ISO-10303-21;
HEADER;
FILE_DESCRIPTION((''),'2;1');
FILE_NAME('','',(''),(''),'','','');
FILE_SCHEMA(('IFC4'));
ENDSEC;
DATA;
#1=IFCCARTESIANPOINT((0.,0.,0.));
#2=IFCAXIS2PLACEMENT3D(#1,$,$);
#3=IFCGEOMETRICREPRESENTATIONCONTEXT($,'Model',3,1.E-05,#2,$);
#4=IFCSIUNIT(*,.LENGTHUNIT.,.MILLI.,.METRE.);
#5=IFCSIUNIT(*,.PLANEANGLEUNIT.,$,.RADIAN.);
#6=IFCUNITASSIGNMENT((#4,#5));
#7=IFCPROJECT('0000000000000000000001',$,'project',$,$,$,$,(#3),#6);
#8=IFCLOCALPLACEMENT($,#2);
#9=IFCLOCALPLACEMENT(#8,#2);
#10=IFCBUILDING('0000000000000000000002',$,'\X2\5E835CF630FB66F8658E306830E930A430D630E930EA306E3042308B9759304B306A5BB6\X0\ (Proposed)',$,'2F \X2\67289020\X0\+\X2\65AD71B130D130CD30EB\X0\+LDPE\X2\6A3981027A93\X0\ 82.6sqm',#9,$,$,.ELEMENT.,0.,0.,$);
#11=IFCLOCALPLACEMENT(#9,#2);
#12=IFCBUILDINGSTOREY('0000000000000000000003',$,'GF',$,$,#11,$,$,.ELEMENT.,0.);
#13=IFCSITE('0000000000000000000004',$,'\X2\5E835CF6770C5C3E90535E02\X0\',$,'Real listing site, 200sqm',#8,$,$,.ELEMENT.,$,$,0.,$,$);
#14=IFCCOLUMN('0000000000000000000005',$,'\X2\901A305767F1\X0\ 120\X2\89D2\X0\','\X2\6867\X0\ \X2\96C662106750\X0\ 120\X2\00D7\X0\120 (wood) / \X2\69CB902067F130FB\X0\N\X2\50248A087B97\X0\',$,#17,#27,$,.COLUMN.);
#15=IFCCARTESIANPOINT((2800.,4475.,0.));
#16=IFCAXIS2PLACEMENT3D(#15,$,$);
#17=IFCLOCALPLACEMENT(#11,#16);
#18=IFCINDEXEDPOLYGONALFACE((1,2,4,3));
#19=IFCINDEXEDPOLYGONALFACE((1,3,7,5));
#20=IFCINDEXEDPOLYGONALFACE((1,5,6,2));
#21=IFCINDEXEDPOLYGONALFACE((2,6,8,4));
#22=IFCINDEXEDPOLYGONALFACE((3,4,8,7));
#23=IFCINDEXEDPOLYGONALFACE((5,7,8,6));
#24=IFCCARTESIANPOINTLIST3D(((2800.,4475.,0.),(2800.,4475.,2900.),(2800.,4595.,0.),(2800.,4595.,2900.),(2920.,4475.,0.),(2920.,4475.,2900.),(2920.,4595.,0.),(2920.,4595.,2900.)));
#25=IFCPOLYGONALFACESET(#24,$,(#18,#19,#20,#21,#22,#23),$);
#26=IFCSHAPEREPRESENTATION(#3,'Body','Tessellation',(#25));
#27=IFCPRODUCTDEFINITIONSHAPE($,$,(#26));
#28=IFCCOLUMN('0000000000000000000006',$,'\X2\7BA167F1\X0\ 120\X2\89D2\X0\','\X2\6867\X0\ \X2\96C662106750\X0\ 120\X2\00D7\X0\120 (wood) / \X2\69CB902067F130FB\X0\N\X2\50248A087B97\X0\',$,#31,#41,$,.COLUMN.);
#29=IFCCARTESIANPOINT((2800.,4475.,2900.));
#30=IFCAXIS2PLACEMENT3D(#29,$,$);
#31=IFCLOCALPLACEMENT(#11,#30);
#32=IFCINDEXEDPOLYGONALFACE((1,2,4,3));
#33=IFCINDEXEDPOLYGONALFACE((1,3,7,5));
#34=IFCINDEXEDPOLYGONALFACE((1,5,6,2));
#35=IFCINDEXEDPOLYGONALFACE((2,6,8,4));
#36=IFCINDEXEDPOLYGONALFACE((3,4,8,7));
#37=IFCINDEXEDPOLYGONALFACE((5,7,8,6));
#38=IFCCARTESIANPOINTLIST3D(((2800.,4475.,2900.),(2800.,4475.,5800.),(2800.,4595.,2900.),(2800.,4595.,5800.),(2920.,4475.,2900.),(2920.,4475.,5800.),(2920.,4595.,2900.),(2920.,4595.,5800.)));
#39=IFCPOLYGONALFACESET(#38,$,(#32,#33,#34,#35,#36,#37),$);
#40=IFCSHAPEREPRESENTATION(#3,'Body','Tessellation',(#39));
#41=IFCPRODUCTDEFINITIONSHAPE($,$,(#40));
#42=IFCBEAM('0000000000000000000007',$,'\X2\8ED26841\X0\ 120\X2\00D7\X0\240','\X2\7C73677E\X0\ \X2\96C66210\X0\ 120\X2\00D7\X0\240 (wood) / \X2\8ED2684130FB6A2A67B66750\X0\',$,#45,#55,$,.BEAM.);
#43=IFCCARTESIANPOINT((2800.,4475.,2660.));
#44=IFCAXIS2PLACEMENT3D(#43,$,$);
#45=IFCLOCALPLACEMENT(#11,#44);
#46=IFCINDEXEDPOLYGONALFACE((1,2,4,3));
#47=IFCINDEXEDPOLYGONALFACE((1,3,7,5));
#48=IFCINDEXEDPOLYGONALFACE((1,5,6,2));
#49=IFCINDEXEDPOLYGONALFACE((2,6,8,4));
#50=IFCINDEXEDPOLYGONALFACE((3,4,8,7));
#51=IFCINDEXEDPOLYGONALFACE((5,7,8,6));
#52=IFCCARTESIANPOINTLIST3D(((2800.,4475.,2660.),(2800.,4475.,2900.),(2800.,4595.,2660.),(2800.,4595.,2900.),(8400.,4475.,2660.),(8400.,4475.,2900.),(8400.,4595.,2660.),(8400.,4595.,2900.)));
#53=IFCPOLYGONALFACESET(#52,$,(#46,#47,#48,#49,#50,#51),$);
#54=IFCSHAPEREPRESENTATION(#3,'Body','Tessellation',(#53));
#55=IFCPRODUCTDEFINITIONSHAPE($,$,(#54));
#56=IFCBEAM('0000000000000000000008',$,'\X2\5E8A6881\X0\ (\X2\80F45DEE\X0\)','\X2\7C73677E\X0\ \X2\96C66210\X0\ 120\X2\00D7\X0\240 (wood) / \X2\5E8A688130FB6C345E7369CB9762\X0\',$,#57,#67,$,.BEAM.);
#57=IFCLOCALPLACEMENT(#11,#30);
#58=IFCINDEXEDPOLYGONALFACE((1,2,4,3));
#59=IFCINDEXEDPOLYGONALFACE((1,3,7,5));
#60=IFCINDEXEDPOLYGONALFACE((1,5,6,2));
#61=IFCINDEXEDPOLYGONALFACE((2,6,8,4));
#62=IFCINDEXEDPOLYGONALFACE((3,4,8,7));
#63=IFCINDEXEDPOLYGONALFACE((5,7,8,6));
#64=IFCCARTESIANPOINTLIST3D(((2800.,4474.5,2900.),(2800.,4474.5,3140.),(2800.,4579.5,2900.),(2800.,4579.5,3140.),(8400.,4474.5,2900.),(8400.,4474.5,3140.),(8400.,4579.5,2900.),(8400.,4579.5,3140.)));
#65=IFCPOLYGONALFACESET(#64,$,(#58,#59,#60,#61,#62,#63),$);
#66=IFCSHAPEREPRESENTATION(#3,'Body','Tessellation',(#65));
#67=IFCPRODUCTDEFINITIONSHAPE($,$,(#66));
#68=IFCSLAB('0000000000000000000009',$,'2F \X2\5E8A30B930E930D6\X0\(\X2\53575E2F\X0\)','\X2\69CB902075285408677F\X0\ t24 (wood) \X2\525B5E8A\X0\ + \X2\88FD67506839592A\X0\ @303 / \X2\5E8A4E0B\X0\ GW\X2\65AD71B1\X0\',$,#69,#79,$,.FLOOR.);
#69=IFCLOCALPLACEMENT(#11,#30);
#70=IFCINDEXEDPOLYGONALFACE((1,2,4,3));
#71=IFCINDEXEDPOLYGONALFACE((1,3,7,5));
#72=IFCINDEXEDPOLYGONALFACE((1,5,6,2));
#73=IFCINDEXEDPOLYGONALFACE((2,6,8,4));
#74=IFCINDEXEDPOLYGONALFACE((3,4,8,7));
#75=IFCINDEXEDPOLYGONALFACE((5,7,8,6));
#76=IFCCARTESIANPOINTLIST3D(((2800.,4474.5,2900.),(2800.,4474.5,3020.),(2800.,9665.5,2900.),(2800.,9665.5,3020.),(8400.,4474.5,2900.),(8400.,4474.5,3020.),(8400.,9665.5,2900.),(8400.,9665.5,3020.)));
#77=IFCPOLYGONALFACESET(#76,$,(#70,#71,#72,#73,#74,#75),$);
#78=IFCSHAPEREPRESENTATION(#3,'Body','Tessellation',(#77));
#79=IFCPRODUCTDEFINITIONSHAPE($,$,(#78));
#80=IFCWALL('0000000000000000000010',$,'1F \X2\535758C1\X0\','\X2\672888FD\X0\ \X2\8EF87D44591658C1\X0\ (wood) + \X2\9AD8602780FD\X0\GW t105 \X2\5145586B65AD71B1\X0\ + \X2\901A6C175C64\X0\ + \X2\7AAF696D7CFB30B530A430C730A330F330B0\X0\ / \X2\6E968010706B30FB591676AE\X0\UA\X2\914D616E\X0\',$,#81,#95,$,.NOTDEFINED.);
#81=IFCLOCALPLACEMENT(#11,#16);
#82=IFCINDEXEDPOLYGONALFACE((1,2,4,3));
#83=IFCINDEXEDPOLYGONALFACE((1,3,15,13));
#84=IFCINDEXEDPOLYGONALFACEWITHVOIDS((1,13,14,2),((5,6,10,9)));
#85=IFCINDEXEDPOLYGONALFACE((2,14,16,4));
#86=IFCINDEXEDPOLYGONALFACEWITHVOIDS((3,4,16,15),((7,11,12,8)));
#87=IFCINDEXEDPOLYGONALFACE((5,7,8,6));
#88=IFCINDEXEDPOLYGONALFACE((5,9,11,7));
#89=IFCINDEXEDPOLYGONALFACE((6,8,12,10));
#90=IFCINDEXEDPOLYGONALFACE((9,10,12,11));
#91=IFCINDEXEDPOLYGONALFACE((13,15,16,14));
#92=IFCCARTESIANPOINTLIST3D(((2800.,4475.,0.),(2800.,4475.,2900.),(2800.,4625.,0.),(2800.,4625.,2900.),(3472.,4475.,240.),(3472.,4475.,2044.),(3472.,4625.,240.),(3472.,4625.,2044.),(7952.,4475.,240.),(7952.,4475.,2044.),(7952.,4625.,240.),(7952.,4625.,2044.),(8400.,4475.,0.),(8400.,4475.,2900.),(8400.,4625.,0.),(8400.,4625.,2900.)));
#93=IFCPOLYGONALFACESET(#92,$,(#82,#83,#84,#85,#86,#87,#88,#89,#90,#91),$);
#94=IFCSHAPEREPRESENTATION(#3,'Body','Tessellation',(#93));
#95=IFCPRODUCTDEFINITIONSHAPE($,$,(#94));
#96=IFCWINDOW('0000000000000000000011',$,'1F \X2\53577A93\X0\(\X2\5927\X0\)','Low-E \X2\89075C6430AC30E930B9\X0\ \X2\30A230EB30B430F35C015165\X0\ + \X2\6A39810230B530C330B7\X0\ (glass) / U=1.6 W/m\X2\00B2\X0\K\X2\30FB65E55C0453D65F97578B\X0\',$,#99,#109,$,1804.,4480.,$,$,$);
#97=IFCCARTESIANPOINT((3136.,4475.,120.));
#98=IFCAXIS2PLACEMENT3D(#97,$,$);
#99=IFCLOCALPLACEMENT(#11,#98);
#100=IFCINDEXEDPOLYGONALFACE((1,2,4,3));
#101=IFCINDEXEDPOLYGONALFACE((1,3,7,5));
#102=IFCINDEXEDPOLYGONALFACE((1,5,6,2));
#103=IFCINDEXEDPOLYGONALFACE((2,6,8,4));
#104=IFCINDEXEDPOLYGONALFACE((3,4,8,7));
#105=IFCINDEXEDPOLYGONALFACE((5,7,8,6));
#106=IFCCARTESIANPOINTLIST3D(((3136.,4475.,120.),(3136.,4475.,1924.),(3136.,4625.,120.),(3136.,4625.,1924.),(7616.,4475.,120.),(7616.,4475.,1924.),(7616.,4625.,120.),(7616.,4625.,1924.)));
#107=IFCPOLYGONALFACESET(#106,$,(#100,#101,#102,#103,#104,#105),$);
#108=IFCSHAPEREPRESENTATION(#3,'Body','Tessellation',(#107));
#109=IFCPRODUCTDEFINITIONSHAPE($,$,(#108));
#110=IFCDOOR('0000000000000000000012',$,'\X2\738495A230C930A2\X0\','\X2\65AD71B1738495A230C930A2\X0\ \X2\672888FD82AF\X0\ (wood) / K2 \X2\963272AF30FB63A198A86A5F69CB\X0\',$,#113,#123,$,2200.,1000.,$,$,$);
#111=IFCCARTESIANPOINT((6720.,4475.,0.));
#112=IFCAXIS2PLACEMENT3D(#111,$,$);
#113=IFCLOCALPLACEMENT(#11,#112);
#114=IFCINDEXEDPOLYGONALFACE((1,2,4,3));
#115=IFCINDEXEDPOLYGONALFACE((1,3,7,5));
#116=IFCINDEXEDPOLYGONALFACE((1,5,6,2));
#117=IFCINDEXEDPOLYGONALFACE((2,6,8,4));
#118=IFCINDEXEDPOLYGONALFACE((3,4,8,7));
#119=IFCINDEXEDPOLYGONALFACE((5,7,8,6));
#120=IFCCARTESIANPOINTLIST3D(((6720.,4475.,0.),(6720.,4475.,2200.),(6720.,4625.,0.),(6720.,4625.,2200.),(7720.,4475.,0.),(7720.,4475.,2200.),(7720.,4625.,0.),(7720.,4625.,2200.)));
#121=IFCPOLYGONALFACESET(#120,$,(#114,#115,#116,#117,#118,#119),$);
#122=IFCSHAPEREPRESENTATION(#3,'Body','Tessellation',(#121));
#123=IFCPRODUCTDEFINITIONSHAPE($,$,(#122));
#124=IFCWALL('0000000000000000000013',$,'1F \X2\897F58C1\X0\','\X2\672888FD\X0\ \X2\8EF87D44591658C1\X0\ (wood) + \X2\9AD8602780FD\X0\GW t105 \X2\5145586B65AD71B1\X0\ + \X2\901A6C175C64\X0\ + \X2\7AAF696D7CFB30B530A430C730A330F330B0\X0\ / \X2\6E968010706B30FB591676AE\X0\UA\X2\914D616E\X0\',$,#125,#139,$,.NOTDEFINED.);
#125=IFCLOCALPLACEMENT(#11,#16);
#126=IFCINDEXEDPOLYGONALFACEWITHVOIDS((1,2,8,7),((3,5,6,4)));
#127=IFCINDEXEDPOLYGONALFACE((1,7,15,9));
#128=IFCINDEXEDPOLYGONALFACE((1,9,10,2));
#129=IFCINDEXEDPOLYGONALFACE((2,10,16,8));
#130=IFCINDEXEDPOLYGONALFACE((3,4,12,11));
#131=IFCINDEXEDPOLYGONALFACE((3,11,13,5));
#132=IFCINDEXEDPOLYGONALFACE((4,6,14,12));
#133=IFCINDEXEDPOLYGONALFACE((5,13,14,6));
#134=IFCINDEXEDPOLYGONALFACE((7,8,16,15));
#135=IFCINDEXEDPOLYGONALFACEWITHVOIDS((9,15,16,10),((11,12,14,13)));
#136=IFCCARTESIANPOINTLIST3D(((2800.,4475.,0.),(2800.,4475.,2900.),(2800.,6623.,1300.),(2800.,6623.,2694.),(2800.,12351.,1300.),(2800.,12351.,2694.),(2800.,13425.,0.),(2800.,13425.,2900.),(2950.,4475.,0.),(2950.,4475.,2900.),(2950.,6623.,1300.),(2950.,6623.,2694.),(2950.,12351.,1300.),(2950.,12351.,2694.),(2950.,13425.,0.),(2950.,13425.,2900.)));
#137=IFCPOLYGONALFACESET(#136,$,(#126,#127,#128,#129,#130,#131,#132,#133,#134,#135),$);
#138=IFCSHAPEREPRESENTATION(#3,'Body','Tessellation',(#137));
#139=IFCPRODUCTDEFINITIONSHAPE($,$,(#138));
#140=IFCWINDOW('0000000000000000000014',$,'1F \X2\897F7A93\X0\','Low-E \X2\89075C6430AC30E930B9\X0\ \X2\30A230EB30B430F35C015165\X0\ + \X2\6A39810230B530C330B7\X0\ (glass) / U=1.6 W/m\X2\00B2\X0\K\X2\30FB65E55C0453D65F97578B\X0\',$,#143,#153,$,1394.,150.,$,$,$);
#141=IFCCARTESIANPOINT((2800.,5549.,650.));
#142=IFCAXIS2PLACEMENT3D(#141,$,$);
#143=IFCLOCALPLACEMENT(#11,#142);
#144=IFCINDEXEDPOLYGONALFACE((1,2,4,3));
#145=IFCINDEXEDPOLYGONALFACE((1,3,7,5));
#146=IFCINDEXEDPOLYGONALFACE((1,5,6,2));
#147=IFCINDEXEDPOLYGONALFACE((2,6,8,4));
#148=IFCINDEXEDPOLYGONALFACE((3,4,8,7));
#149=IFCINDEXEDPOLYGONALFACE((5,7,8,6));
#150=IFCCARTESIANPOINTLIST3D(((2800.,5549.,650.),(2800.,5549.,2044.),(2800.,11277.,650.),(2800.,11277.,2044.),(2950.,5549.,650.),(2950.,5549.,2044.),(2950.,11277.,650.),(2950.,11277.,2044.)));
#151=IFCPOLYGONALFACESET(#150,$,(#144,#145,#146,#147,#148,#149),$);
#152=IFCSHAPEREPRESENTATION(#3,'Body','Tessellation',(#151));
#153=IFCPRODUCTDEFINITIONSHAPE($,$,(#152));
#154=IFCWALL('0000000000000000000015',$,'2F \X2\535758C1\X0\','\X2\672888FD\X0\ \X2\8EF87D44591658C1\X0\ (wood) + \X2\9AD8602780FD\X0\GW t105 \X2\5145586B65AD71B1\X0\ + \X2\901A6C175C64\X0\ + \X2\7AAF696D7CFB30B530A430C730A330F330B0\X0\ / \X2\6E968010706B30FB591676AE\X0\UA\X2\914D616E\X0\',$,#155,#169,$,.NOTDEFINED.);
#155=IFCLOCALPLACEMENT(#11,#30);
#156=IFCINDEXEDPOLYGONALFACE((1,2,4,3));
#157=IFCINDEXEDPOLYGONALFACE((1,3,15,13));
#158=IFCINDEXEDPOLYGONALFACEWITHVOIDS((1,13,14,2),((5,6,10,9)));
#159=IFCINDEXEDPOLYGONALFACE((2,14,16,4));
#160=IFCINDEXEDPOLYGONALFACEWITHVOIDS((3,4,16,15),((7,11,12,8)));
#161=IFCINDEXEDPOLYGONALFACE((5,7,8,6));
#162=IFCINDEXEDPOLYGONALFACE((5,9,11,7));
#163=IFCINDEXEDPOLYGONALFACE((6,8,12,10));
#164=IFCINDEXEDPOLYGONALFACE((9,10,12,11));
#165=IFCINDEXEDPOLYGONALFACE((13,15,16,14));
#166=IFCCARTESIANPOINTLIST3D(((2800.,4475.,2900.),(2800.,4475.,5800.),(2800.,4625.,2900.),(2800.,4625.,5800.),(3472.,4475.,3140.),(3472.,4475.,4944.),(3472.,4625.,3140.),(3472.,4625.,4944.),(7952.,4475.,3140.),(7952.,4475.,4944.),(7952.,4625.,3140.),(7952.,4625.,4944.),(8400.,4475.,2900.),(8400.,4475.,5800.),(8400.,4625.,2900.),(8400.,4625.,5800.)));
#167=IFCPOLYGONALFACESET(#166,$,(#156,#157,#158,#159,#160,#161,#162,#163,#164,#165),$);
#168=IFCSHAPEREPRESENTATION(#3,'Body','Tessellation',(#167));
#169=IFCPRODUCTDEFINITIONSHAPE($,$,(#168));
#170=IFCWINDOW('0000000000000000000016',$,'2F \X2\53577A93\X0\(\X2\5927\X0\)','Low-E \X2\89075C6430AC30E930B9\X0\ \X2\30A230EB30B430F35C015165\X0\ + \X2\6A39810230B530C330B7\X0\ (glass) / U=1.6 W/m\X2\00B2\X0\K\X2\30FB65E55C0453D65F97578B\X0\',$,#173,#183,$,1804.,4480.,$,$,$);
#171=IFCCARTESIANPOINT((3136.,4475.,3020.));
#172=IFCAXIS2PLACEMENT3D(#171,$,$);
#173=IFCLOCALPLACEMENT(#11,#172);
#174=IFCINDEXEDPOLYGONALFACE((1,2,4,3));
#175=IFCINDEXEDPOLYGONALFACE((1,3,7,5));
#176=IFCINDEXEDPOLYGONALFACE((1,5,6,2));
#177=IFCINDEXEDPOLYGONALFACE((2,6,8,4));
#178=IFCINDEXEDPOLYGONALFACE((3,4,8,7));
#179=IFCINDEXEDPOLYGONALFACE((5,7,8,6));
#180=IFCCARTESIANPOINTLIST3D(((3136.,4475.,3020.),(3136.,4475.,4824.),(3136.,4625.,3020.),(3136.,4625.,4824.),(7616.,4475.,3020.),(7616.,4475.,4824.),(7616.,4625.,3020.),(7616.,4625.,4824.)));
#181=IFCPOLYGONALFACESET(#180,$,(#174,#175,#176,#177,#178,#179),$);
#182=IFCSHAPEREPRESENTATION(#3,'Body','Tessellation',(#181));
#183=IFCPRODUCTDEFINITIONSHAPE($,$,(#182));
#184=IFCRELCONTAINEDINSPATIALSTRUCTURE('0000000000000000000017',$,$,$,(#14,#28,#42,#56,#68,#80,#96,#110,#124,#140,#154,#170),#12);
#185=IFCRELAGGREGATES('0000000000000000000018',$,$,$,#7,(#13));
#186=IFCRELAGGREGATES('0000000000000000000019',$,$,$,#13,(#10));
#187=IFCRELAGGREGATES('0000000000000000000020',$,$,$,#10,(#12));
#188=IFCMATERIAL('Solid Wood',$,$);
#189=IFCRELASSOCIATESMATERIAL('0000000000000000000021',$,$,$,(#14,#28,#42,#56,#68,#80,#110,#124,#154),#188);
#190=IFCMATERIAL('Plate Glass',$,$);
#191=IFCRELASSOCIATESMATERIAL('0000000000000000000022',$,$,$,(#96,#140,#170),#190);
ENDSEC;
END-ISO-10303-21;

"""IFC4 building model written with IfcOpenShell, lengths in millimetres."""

from ifc_helpers import new_model, si_unit, frame, frame_2d, origin, place, context, project, spatial, rectangle, extrude, material, element, fill, save


model = new_model("IFC4")

# Units and contexts
model_context = context("Model", 3, precision=1e-05, world=origin())
ifc_project = project(units=[si_unit("LENGTHUNIT", "METRE", prefix="MILLI"), si_unit("PLANEANGLEUNIT", "RADIAN")], contexts=[model_context])

# Site, building, storey
site_placement = place(None, origin())
site = spatial("IfcSite", under=ifc_project, at=site_placement, Name="広島県尾道市", ObjectType="Real listing site, 200sqm", CompositionType="ELEMENT", RefElevation=0.0)
building_placement = place(site_placement, origin())
building = spatial("IfcBuilding", under=site, at=building_placement, Name="広島・書斎とライブラリのある静かな家 (Proposed)", ObjectType="2F 木造+断熱パネル+LDPE樹脂窓 82.6sqm", CompositionType="ELEMENT", ElevationOfRefHeight=0.0, ElevationOfTerrain=0.0)
storey_placement = place(building_placement, origin())
storey = spatial("IfcBuildingStorey", under=building, at=storey_placement, Name="GF", CompositionType="ELEMENT", Elevation=0.0)

# Columns
ifc_material_1 = material(Name="Solid Wood")
column_1_placement = place(storey_placement, frame((2800.0, 4475.0, 0.0)))
element("IfcColumn", 1, at=column_1_placement, inside=storey, material=ifc_material_1, Name="通し柱 120角", Description="桧 集成材 120×120 (wood) / 構造柱・N値計算", PredefinedType="COLUMN", context=model_context, shape_type="SweptSolid", body=[
    extrude(rectangle(XDim=120.0, YDim=120.0, at=frame_2d((60.0, 60.0))), frame((2800.0, 4475.0, 0.0)), (0.0, 0.0, 1.0), 2900.0),
])
column_2_placement = place(storey_placement, frame((2800.0, 4475.0, 2900.0)))
element("IfcColumn", 2, at=column_2_placement, inside=storey, material=ifc_material_1, Name="管柱 120角", Description="桧 集成材 120×120 (wood) / 構造柱・N値計算", PredefinedType="COLUMN", context=model_context, shape_type="SweptSolid", body=[
    extrude(rectangle(XDim=120.0, YDim=120.0, at=frame_2d((60.0, 60.0))), frame((2800.0, 4475.0, 2900.0)), (0.0, 0.0, 1.0), 2900.0),
])

# Beams
beam_1_placement = place(storey_placement, frame((2800.0, 4475.0, 2660.0)))
element("IfcBeam", 3, at=beam_1_placement, inside=storey, material=ifc_material_1, Name="軒桁 120×240", Description="米松 集成 120×240 (wood) / 軒桁・横架材", PredefinedType="BEAM", context=model_context, shape_type="SweptSolid", body=[
    extrude(rectangle(XDim=5600.0, YDim=120.0, at=frame_2d((2800.0, 60.0))), frame((2800.0, 4475.0, 2660.0)), (0.0, 0.0, 1.0), 240.0),
])
beam_2_placement = place(storey_placement, frame((2800.0, 4475.0, 2900.0)))
element("IfcBeam", 4, at=beam_2_placement, inside=storey, material=ifc_material_1, Name="床梁 (胴差)", Description="米松 集成 120×240 (wood) / 床梁・水平構面", PredefinedType="BEAM", context=model_context, shape_type="SweptSolid", body=[
    extrude(rectangle(XDim=5600.0, YDim=105.0, at=frame_2d((2800.0, 52.0))), frame((2800.0, 4475.0, 2900.0)), (0.0, 0.0, 1.0), 240.0),
])

# Slab
slab_1_placement = place(storey_placement, frame((2800.0, 4475.0, 2900.0)))
element("IfcSlab", 5, at=slab_1_placement, inside=storey, material=ifc_material_1, Name="2F 床スラブ(南帯)", Description="構造用合板 t24 (wood) 剛床 + 製材根太 @303 / 床下 GW断熱", PredefinedType="FLOOR", context=model_context, shape_type="SweptSolid", body=[
    extrude(rectangle(XDim=5600.0, YDim=5191.0, at=frame_2d((2800.0, 2595.0))), frame((2800.0, 4475.0, 2900.0)), (0.0, 0.0, 1.0), 120.0),
])

# Wall, openings, window, door
wall_1_placement = place(storey_placement, frame((2800.0, 4475.0, 0.0)))
wall_1 = element("IfcWall", 6, at=wall_1_placement, inside=storey, material=ifc_material_1, Name="1F 南壁", Description="木製 軸組外壁 (wood) + 高性能GW t105 充填断熱 + 通気層 + 窯業系サイディング / 準耐火・外皮UA配慮", PredefinedType="NOTDEFINED", context=model_context, shape_type="SweptSolid", body=[
    extrude(rectangle(XDim=5600.0, YDim=150.0, at=frame_2d((2800.0, 75.0))), frame((2800.0, 4475.0, 0.0)), (0.0, 0.0, 1.0), 2900.0),
])
opening_1_placement = place(storey_placement, frame((3136.0, 4475.0, 120.0)))
opening_1 = element("IfcOpeningElement", 7, at=opening_1_placement, cuts=wall_1, PredefinedType="NOTDEFINED", context=model_context, shape_type="SweptSolid", body=[
    extrude(rectangle(XDim=4480.0, YDim=150.0, at=frame_2d((2240.0, 75.0))), frame((3136.0, 4475.0, 120.0)), (0.0, 0.0, 1.0), 1804.0),
])
opening_2_placement = place(storey_placement, frame((6720.0, 4475.0, 0.0)))
opening_2 = element("IfcOpeningElement", 8, at=opening_2_placement, cuts=wall_1, PredefinedType="NOTDEFINED", context=model_context, shape_type="SweptSolid", body=[
    extrude(rectangle(XDim=1000.0, YDim=150.0, at=frame_2d((500.0, 75.0))), frame((6720.0, 4475.0, 0.0)), (0.0, 0.0, 1.0), 2200.0),
])
ifc_material_2 = material(Name="Plate Glass")
window_1_placement = place(storey_placement, frame((3136.0, 4475.0, 120.0)))
window_1 = element("IfcWindow", 9, at=window_1_placement, inside=storey, material=ifc_material_2, Name="1F 南窓(大)", Description="Low-E 複層ガラス アルゴン封入 + 樹脂サッシ (glass) / U=1.6 W/m²K・日射取得型", OverallHeight=1804.0, OverallWidth=4480.0, context=model_context, shape_type="SweptSolid", body=[
    extrude(rectangle(XDim=4480.0, YDim=150.0, at=frame_2d((2240.0, 75.0))), frame((3136.0, 4475.0, 120.0)), (0.0, 0.0, 1.0), 1804.0),
])
fill(opening_1, window_1)
door_placement = place(storey_placement, frame((6720.0, 4475.0, 0.0)))
door = element("IfcDoor", 10, at=door_placement, inside=storey, material=ifc_material_1, Name="玄関ドア", Description="断熱玄関ドア 木製芯 (wood) / K2 防犯・採風機構", OverallHeight=2200.0, OverallWidth=1000.0, context=model_context, shape_type="SweptSolid", body=[
    extrude(rectangle(XDim=1000.0, YDim=150.0, at=frame_2d((500.0, 75.0))), frame((6720.0, 4475.0, 0.0)), (0.0, 0.0, 1.0), 2200.0),
])
fill(opening_2, door)

# Walls, openings, windows
wall_2_placement = place(storey_placement, frame((2800.0, 4475.0, 0.0)))
wall_2 = element("IfcWall", 11, at=wall_2_placement, inside=storey, material=ifc_material_1, Name="1F 西壁", Description="木製 軸組外壁 (wood) + 高性能GW t105 充填断熱 + 通気層 + 窯業系サイディング / 準耐火・外皮UA配慮", PredefinedType="NOTDEFINED", context=model_context, shape_type="SweptSolid", body=[
    extrude(rectangle(XDim=150.0, YDim=8950.0, at=frame_2d((75.0, 4475.0))), frame((2800.0, 4475.0, 0.0)), (0.0, 0.0, 1.0), 2900.0),
])
opening_3_placement = place(storey_placement, frame((2800.0, 5549.0, 650.0)))
opening_3 = element("IfcOpeningElement", 12, at=opening_3_placement, cuts=wall_2, PredefinedType="NOTDEFINED", context=model_context, shape_type="SweptSolid", body=[
    extrude(rectangle(XDim=150.0, YDim=5728.0, at=frame_2d((75.0, 2864.0))), frame((2800.0, 5549.0, 650.0)), (0.0, 0.0, 1.0), 1394.0),
])
window_2_placement = place(storey_placement, frame((2800.0, 5549.0, 650.0)))
window_2 = element("IfcWindow", 13, at=window_2_placement, inside=storey, material=ifc_material_2, Name="1F 西窓", Description="Low-E 複層ガラス アルゴン封入 + 樹脂サッシ (glass) / U=1.6 W/m²K・日射取得型", OverallHeight=1394.0, OverallWidth=150.0, context=model_context, shape_type="SweptSolid", body=[
    extrude(rectangle(XDim=150.0, YDim=5728.0, at=frame_2d((75.0, 2864.0))), frame((2800.0, 5549.0, 650.0)), (0.0, 0.0, 1.0), 1394.0),
])
fill(opening_3, window_2)
wall_3_placement = place(storey_placement, frame((2800.0, 4475.0, 2900.0)))
wall_3 = element("IfcWall", 14, at=wall_3_placement, inside=storey, material=ifc_material_1, Name="2F 南壁", Description="木製 軸組外壁 (wood) + 高性能GW t105 充填断熱 + 通気層 + 窯業系サイディング / 準耐火・外皮UA配慮", PredefinedType="NOTDEFINED", context=model_context, shape_type="SweptSolid", body=[
    extrude(rectangle(XDim=5600.0, YDim=150.0, at=frame_2d((2800.0, 75.0))), frame((2800.0, 4475.0, 2900.0)), (0.0, 0.0, 1.0), 2900.0),
])
opening_4_placement = place(storey_placement, frame((3136.0, 4475.0, 3020.0)))
opening_4 = element("IfcOpeningElement", 15, at=opening_4_placement, cuts=wall_3, PredefinedType="NOTDEFINED", context=model_context, shape_type="SweptSolid", body=[
    extrude(rectangle(XDim=4480.0, YDim=150.0, at=frame_2d((2240.0, 75.0))), frame((3136.0, 4475.0, 3020.0)), (0.0, 0.0, 1.0), 1804.0),
])
window_3_placement = place(storey_placement, frame((3136.0, 4475.0, 3020.0)))
window_3 = element("IfcWindow", 16, at=window_3_placement, inside=storey, material=ifc_material_2, Name="2F 南窓(大)", Description="Low-E 複層ガラス アルゴン封入 + 樹脂サッシ (glass) / U=1.6 W/m²K・日射取得型", OverallHeight=1804.0, OverallWidth=4480.0, context=model_context, shape_type="SweptSolid", body=[
    extrude(rectangle(XDim=4480.0, YDim=150.0, at=frame_2d((2240.0, 75.0))), frame((3136.0, 4475.0, 3020.0)), (0.0, 0.0, 1.0), 1804.0),
])
fill(opening_4, window_3)

save(model, "model.ifc")
